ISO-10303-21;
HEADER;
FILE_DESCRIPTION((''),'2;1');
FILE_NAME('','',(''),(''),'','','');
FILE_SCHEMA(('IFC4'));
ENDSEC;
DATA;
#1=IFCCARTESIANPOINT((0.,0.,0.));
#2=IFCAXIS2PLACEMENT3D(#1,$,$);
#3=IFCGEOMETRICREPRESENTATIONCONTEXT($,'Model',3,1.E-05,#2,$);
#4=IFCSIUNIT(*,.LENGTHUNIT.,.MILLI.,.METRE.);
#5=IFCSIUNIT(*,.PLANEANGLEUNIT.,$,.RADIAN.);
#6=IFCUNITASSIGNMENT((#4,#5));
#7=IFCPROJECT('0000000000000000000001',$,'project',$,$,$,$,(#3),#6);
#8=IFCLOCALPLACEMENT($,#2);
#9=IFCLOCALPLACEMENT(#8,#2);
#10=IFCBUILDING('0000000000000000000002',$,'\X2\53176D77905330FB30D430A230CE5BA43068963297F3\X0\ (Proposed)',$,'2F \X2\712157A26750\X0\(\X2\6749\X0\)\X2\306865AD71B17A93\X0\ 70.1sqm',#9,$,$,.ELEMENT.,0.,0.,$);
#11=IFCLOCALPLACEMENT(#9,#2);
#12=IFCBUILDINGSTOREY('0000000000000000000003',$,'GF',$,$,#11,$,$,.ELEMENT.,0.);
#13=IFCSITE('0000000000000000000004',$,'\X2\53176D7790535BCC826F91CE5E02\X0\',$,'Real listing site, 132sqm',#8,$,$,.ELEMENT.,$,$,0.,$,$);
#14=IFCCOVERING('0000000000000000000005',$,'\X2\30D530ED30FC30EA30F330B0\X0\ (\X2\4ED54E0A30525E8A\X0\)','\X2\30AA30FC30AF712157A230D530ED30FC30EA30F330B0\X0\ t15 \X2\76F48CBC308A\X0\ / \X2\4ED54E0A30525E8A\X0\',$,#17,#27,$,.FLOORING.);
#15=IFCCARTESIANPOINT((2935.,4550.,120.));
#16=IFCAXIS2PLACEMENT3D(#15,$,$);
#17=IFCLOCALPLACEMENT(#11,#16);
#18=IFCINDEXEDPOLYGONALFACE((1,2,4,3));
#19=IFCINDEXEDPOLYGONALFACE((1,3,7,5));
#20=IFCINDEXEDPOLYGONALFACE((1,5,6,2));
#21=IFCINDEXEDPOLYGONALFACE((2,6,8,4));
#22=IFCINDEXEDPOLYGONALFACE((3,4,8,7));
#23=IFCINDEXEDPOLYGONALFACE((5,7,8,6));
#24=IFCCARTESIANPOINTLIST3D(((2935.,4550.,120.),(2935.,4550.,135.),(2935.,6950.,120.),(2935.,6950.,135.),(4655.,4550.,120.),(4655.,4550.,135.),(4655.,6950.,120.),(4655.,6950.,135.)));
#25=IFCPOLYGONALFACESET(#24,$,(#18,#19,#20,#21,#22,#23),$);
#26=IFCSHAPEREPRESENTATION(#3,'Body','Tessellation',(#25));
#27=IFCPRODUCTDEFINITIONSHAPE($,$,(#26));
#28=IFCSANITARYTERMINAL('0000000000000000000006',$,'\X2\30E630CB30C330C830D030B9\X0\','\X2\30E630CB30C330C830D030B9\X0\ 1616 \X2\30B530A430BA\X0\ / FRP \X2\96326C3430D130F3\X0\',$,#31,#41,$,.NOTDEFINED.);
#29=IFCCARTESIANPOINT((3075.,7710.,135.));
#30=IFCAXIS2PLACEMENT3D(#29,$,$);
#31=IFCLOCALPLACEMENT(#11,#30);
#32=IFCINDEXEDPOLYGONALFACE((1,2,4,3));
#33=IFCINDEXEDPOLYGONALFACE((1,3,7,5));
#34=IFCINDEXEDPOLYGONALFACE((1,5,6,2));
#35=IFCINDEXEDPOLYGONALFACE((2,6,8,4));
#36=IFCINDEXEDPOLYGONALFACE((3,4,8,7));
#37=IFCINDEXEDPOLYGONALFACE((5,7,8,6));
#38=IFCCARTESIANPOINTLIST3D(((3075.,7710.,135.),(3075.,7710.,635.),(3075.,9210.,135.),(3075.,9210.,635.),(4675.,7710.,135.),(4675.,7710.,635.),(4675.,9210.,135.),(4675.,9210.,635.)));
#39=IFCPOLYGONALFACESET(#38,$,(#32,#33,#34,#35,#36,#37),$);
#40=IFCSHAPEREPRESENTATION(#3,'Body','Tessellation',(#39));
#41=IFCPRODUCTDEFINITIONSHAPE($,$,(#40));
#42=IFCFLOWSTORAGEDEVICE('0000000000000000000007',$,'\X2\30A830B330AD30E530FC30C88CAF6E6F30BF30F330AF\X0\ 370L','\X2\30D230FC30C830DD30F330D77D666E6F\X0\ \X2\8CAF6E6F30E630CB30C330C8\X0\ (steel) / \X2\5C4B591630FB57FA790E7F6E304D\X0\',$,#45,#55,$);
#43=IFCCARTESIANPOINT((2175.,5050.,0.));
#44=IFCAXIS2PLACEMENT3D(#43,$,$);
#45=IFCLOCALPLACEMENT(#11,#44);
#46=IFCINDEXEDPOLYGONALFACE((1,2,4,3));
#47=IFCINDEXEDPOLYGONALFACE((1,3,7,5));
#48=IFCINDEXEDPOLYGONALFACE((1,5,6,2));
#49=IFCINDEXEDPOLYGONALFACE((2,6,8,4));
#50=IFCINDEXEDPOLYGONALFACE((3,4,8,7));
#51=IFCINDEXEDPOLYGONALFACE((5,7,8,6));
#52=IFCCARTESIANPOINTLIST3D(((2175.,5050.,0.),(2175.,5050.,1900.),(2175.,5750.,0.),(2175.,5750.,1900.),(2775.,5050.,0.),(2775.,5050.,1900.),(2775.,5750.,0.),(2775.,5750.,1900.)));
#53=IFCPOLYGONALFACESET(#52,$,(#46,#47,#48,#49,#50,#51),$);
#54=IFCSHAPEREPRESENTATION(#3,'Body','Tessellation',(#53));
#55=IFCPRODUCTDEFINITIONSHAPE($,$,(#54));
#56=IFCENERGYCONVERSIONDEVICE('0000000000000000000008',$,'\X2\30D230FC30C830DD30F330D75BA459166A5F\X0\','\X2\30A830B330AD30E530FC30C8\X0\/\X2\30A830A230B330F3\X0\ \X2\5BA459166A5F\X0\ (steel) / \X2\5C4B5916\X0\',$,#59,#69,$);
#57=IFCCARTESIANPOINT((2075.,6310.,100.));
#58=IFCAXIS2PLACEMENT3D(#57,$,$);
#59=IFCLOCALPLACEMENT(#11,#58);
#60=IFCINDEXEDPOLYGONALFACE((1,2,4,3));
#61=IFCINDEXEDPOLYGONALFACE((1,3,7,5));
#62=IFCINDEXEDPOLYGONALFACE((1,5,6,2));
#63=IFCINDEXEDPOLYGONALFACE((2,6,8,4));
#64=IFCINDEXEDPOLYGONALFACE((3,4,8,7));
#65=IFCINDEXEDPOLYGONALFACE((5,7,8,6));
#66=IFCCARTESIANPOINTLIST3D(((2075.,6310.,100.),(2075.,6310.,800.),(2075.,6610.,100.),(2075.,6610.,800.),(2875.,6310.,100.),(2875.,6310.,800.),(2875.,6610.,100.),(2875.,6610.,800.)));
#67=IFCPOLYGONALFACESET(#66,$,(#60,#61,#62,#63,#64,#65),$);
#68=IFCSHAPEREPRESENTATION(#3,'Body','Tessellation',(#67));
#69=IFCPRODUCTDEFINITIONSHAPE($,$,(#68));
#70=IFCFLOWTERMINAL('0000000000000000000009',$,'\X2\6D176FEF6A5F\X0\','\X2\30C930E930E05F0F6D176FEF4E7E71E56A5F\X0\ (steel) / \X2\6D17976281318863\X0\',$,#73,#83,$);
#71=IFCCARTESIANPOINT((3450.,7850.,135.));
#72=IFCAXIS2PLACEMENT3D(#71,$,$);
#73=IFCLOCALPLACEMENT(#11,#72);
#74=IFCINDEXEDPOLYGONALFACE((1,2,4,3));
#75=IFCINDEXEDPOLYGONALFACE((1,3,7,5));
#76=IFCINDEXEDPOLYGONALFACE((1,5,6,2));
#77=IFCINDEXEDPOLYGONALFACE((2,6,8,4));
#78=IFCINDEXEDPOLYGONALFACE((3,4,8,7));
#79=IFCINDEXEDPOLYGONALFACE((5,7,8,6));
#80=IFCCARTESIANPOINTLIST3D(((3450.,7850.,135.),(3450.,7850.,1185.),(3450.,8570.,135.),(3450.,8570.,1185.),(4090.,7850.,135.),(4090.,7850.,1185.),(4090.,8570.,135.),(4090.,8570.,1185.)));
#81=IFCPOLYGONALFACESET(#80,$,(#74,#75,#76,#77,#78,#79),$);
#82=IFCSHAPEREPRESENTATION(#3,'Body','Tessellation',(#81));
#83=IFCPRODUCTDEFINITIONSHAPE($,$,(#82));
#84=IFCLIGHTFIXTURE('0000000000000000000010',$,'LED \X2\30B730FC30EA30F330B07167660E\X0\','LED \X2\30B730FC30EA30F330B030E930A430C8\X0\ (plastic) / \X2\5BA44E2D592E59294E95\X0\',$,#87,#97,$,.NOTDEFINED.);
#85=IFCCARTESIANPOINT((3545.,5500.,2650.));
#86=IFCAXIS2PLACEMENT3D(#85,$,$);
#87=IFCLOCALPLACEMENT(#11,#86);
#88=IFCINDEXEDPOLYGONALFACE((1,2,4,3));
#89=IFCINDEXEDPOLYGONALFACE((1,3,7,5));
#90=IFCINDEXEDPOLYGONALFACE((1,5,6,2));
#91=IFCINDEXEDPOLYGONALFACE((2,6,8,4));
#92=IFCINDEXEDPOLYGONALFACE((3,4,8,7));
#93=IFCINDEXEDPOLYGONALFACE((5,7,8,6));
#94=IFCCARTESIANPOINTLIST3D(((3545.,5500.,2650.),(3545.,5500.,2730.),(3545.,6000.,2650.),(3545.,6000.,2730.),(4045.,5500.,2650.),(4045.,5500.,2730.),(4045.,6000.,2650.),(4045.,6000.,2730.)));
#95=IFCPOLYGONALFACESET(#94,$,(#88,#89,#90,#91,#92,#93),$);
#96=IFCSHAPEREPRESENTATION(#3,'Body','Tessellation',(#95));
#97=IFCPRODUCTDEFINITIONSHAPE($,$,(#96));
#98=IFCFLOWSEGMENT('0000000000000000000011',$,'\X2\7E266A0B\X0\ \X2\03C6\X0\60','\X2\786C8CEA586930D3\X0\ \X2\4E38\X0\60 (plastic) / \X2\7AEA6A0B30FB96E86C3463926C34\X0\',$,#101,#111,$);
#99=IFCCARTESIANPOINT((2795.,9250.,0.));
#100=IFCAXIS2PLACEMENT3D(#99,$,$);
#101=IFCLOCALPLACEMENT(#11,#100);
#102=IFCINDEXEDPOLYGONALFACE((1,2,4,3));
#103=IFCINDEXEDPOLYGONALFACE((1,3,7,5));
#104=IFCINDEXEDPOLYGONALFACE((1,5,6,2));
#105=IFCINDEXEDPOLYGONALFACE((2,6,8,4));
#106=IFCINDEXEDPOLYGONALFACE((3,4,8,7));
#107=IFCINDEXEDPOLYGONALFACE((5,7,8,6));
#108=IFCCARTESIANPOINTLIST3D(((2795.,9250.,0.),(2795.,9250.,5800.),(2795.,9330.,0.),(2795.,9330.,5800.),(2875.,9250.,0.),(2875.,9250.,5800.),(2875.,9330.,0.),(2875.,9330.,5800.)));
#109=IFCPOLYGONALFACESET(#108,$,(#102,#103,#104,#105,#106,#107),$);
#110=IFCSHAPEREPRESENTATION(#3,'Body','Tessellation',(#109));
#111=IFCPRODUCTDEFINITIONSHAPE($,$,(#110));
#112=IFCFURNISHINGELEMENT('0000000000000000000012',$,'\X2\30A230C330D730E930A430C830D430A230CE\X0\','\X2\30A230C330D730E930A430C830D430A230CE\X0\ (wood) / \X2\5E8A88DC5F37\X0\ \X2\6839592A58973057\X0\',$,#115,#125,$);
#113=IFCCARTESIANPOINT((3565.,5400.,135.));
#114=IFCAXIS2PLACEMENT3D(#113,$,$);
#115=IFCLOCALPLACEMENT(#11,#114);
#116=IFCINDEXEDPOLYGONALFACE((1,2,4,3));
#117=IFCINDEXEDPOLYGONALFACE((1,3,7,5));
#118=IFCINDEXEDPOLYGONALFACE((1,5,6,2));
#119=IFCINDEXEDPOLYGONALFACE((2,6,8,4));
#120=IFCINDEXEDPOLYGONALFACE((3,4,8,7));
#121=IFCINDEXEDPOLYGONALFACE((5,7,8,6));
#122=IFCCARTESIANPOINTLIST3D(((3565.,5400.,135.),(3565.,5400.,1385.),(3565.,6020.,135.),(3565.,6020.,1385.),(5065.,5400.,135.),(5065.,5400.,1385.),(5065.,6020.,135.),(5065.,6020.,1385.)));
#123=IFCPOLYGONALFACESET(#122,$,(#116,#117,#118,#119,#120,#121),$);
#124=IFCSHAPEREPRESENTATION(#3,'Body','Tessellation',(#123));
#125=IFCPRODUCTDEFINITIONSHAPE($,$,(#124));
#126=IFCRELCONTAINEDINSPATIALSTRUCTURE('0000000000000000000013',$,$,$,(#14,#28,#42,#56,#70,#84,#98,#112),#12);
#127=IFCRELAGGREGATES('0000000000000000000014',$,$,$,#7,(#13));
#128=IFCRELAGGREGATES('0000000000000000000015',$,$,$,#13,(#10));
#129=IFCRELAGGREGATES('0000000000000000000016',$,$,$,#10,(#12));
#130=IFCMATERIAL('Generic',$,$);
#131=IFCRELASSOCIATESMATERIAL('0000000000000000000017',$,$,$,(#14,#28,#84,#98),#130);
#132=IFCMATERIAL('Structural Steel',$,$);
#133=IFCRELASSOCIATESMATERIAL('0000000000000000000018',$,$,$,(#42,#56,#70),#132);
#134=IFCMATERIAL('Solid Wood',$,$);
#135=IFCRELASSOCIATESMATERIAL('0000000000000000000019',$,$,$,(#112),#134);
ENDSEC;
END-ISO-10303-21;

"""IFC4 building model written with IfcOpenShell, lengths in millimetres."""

from ifc_helpers import new_model, si_unit, frame, frame_2d, origin, place, context, project, spatial, rectangle, extrude, material, element, save


model = new_model("IFC4")

# Units and contexts
model_context = context("Model", 3, precision=1e-05, world=origin())
ifc_project = project(units=[si_unit("LENGTHUNIT", "METRE", prefix="MILLI"), si_unit("PLANEANGLEUNIT", "RADIAN")], contexts=[model_context])

# Site, building, storey
site_placement = place(None, origin())
site = spatial("IfcSite", under=ifc_project, at=site_placement, Name="北海道富良野市", ObjectType="Real listing site, 132sqm", CompositionType="ELEMENT", RefElevation=0.0)
building_placement = place(site_placement, origin())
building = spatial("IfcBuilding", under=site, at=building_placement, Name="北海道・ピアノ室と防音 (Proposed)", ObjectType="2F 無垢材(杉)と断熱窓 70.1sqm", CompositionType="ELEMENT", ElevationOfRefHeight=0.0, ElevationOfTerrain=0.0)
storey_placement = place(building_placement, origin())
storey = spatial("IfcBuildingStorey", under=building, at=storey_placement, Name="GF", CompositionType="ELEMENT", Elevation=0.0)

# Shared definitions
ifc_material_1 = material(Name="Solid Wood")

# Covering
ifc_material_2 = material(Name="Generic")
covering_1_placement = place(storey_placement, frame((2935.0, 4550.0, 120.0)))
element("IfcCovering", 1, at=covering_1_placement, inside=storey, material=ifc_material_2, Name="フローリング (仕上げ床)", Description="オーク無垢フローリング t15 直貼り / 仕上げ床", PredefinedType="FLOORING", context=model_context, shape_type="SweptSolid", body=[
    extrude(rectangle(XDim=1720.0, YDim=2400.0, at=frame_2d((860.0, 1200.0))), frame((2935.0, 4550.0, 120.0)), (0.0, 0.0, 1.0), 15.0),
])

# Sanitary terminal
sanitary_terminal_placement = place(storey_placement, frame((3075.0, 7710.0, 135.0)))
element("IfcSanitaryTerminal", 2, at=sanitary_terminal_placement, inside=storey, material=ifc_material_2, Name="ユニットバス", Description="ユニットバス 1616 サイズ / FRP 防水パン", PredefinedType="NOTDEFINED", context=model_context, shape_type="SweptSolid", body=[
    extrude(rectangle(XDim=1600.0, YDim=1500.0, at=frame_2d((800.0, 750.0))), frame((3075.0, 7710.0, 135.0)), (0.0, 0.0, 1.0), 500.0),
])

# Flow storage device
ifc_material_3 = material(Name="Structural Steel")
flow_storage_device_placement = place(storey_placement, frame((2175.0, 5050.0, 0.0)))
element("IfcFlowStorageDevice", 3, at=flow_storage_device_placement, inside=storey, material=ifc_material_3, Name="エコキュート貯湯タンク 370L", Description="ヒートポンプ給湯 貯湯ユニット (steel) / 屋外・基礎置き", context=model_context, shape_type="SweptSolid", body=[
    extrude(rectangle(XDim=600.0, YDim=700.0, at=frame_2d((300.0, 350.0))), frame((2175.0, 5050.0, 0.0)), (0.0, 0.0, 1.0), 1900.0),
])

# Energy conversion device
energy_conversion_device_placement = place(storey_placement, frame((2075.0, 6310.0, 100.0)))
element("IfcEnergyConversionDevice", 4, at=energy_conversion_device_placement, inside=storey, material=ifc_material_3, Name="ヒートポンプ室外機", Description="エコキュート/エアコン 室外機 (steel) / 屋外", context=model_context, shape_type="SweptSolid", body=[
    extrude(rectangle(XDim=800.0, YDim=300.0, at=frame_2d((400.0, 150.0))), frame((2075.0, 6310.0, 100.0)), (0.0, 0.0, 1.0), 700.0),
])

# Flow terminal
flow_terminal_placement = place(storey_placement, frame((3450.0, 7850.0, 135.0)))
element("IfcFlowTerminal", 5, at=flow_terminal_placement, inside=storey, material=ifc_material_3, Name="洗濯機", Description="ドラム式洗濯乾燥機 (steel) / 洗面脱衣", context=model_context, shape_type="SweptSolid", body=[
    extrude(rectangle(XDim=640.0, YDim=720.0, at=frame_2d((320.0, 360.0))), frame((3450.0, 7850.0, 135.0)), (0.0, 0.0, 1.0), 1050.0),
])

# Light fixture
light_fixture_placement = place(storey_placement, frame((3545.0, 5500.0, 2650.0)))
element("IfcLightFixture", 6, at=light_fixture_placement, inside=storey, material=ifc_material_2, Name="LED シーリング照明", Description="LED シーリングライト (plastic) / 室中央天井", PredefinedType="NOTDEFINED", context=model_context, shape_type="SweptSolid", body=[
    extrude(rectangle(XDim=500.0, YDim=500.0, at=frame_2d((250.0, 250.0))), frame((3545.0, 5500.0, 2650.0)), (0.0, 0.0, 1.0), 80.0),
])

# Flow segment
flow_segment_placement = place(storey_placement, frame((2795.0, 9250.0, 0.0)))
element("IfcFlowSegment", 7, at=flow_segment_placement, inside=storey, material=ifc_material_2, Name="縦樋 φ60", Description="硬質塩ビ 丸60 (plastic) / 竪樋・雨水排水", context=model_context, shape_type="SweptSolid", body=[
    extrude(rectangle(XDim=80.0, YDim=80.0, at=frame_2d((40.0, 40.0))), frame((2795.0, 9250.0, 0.0)), (0.0, 0.0, 1.0), 5800.0),
])

# Furnishing element
furnishing_placement = place(storey_placement, frame((3565.0, 5400.0, 135.0)))
element("IfcFurnishingElement", 8, at=furnishing_placement, inside=storey, material=ifc_material_1, Name="アップライトピアノ", Description="アップライトピアノ (wood) / 床補強 根太増し", context=model_context, shape_type="SweptSolid", body=[
    extrude(rectangle(XDim=1500.0, YDim=620.0, at=frame_2d((750.0, 310.0))), frame((3565.0, 5400.0, 135.0)), (0.0, 0.0, 1.0), 1250.0),
])

save(model, "model.ifc")
